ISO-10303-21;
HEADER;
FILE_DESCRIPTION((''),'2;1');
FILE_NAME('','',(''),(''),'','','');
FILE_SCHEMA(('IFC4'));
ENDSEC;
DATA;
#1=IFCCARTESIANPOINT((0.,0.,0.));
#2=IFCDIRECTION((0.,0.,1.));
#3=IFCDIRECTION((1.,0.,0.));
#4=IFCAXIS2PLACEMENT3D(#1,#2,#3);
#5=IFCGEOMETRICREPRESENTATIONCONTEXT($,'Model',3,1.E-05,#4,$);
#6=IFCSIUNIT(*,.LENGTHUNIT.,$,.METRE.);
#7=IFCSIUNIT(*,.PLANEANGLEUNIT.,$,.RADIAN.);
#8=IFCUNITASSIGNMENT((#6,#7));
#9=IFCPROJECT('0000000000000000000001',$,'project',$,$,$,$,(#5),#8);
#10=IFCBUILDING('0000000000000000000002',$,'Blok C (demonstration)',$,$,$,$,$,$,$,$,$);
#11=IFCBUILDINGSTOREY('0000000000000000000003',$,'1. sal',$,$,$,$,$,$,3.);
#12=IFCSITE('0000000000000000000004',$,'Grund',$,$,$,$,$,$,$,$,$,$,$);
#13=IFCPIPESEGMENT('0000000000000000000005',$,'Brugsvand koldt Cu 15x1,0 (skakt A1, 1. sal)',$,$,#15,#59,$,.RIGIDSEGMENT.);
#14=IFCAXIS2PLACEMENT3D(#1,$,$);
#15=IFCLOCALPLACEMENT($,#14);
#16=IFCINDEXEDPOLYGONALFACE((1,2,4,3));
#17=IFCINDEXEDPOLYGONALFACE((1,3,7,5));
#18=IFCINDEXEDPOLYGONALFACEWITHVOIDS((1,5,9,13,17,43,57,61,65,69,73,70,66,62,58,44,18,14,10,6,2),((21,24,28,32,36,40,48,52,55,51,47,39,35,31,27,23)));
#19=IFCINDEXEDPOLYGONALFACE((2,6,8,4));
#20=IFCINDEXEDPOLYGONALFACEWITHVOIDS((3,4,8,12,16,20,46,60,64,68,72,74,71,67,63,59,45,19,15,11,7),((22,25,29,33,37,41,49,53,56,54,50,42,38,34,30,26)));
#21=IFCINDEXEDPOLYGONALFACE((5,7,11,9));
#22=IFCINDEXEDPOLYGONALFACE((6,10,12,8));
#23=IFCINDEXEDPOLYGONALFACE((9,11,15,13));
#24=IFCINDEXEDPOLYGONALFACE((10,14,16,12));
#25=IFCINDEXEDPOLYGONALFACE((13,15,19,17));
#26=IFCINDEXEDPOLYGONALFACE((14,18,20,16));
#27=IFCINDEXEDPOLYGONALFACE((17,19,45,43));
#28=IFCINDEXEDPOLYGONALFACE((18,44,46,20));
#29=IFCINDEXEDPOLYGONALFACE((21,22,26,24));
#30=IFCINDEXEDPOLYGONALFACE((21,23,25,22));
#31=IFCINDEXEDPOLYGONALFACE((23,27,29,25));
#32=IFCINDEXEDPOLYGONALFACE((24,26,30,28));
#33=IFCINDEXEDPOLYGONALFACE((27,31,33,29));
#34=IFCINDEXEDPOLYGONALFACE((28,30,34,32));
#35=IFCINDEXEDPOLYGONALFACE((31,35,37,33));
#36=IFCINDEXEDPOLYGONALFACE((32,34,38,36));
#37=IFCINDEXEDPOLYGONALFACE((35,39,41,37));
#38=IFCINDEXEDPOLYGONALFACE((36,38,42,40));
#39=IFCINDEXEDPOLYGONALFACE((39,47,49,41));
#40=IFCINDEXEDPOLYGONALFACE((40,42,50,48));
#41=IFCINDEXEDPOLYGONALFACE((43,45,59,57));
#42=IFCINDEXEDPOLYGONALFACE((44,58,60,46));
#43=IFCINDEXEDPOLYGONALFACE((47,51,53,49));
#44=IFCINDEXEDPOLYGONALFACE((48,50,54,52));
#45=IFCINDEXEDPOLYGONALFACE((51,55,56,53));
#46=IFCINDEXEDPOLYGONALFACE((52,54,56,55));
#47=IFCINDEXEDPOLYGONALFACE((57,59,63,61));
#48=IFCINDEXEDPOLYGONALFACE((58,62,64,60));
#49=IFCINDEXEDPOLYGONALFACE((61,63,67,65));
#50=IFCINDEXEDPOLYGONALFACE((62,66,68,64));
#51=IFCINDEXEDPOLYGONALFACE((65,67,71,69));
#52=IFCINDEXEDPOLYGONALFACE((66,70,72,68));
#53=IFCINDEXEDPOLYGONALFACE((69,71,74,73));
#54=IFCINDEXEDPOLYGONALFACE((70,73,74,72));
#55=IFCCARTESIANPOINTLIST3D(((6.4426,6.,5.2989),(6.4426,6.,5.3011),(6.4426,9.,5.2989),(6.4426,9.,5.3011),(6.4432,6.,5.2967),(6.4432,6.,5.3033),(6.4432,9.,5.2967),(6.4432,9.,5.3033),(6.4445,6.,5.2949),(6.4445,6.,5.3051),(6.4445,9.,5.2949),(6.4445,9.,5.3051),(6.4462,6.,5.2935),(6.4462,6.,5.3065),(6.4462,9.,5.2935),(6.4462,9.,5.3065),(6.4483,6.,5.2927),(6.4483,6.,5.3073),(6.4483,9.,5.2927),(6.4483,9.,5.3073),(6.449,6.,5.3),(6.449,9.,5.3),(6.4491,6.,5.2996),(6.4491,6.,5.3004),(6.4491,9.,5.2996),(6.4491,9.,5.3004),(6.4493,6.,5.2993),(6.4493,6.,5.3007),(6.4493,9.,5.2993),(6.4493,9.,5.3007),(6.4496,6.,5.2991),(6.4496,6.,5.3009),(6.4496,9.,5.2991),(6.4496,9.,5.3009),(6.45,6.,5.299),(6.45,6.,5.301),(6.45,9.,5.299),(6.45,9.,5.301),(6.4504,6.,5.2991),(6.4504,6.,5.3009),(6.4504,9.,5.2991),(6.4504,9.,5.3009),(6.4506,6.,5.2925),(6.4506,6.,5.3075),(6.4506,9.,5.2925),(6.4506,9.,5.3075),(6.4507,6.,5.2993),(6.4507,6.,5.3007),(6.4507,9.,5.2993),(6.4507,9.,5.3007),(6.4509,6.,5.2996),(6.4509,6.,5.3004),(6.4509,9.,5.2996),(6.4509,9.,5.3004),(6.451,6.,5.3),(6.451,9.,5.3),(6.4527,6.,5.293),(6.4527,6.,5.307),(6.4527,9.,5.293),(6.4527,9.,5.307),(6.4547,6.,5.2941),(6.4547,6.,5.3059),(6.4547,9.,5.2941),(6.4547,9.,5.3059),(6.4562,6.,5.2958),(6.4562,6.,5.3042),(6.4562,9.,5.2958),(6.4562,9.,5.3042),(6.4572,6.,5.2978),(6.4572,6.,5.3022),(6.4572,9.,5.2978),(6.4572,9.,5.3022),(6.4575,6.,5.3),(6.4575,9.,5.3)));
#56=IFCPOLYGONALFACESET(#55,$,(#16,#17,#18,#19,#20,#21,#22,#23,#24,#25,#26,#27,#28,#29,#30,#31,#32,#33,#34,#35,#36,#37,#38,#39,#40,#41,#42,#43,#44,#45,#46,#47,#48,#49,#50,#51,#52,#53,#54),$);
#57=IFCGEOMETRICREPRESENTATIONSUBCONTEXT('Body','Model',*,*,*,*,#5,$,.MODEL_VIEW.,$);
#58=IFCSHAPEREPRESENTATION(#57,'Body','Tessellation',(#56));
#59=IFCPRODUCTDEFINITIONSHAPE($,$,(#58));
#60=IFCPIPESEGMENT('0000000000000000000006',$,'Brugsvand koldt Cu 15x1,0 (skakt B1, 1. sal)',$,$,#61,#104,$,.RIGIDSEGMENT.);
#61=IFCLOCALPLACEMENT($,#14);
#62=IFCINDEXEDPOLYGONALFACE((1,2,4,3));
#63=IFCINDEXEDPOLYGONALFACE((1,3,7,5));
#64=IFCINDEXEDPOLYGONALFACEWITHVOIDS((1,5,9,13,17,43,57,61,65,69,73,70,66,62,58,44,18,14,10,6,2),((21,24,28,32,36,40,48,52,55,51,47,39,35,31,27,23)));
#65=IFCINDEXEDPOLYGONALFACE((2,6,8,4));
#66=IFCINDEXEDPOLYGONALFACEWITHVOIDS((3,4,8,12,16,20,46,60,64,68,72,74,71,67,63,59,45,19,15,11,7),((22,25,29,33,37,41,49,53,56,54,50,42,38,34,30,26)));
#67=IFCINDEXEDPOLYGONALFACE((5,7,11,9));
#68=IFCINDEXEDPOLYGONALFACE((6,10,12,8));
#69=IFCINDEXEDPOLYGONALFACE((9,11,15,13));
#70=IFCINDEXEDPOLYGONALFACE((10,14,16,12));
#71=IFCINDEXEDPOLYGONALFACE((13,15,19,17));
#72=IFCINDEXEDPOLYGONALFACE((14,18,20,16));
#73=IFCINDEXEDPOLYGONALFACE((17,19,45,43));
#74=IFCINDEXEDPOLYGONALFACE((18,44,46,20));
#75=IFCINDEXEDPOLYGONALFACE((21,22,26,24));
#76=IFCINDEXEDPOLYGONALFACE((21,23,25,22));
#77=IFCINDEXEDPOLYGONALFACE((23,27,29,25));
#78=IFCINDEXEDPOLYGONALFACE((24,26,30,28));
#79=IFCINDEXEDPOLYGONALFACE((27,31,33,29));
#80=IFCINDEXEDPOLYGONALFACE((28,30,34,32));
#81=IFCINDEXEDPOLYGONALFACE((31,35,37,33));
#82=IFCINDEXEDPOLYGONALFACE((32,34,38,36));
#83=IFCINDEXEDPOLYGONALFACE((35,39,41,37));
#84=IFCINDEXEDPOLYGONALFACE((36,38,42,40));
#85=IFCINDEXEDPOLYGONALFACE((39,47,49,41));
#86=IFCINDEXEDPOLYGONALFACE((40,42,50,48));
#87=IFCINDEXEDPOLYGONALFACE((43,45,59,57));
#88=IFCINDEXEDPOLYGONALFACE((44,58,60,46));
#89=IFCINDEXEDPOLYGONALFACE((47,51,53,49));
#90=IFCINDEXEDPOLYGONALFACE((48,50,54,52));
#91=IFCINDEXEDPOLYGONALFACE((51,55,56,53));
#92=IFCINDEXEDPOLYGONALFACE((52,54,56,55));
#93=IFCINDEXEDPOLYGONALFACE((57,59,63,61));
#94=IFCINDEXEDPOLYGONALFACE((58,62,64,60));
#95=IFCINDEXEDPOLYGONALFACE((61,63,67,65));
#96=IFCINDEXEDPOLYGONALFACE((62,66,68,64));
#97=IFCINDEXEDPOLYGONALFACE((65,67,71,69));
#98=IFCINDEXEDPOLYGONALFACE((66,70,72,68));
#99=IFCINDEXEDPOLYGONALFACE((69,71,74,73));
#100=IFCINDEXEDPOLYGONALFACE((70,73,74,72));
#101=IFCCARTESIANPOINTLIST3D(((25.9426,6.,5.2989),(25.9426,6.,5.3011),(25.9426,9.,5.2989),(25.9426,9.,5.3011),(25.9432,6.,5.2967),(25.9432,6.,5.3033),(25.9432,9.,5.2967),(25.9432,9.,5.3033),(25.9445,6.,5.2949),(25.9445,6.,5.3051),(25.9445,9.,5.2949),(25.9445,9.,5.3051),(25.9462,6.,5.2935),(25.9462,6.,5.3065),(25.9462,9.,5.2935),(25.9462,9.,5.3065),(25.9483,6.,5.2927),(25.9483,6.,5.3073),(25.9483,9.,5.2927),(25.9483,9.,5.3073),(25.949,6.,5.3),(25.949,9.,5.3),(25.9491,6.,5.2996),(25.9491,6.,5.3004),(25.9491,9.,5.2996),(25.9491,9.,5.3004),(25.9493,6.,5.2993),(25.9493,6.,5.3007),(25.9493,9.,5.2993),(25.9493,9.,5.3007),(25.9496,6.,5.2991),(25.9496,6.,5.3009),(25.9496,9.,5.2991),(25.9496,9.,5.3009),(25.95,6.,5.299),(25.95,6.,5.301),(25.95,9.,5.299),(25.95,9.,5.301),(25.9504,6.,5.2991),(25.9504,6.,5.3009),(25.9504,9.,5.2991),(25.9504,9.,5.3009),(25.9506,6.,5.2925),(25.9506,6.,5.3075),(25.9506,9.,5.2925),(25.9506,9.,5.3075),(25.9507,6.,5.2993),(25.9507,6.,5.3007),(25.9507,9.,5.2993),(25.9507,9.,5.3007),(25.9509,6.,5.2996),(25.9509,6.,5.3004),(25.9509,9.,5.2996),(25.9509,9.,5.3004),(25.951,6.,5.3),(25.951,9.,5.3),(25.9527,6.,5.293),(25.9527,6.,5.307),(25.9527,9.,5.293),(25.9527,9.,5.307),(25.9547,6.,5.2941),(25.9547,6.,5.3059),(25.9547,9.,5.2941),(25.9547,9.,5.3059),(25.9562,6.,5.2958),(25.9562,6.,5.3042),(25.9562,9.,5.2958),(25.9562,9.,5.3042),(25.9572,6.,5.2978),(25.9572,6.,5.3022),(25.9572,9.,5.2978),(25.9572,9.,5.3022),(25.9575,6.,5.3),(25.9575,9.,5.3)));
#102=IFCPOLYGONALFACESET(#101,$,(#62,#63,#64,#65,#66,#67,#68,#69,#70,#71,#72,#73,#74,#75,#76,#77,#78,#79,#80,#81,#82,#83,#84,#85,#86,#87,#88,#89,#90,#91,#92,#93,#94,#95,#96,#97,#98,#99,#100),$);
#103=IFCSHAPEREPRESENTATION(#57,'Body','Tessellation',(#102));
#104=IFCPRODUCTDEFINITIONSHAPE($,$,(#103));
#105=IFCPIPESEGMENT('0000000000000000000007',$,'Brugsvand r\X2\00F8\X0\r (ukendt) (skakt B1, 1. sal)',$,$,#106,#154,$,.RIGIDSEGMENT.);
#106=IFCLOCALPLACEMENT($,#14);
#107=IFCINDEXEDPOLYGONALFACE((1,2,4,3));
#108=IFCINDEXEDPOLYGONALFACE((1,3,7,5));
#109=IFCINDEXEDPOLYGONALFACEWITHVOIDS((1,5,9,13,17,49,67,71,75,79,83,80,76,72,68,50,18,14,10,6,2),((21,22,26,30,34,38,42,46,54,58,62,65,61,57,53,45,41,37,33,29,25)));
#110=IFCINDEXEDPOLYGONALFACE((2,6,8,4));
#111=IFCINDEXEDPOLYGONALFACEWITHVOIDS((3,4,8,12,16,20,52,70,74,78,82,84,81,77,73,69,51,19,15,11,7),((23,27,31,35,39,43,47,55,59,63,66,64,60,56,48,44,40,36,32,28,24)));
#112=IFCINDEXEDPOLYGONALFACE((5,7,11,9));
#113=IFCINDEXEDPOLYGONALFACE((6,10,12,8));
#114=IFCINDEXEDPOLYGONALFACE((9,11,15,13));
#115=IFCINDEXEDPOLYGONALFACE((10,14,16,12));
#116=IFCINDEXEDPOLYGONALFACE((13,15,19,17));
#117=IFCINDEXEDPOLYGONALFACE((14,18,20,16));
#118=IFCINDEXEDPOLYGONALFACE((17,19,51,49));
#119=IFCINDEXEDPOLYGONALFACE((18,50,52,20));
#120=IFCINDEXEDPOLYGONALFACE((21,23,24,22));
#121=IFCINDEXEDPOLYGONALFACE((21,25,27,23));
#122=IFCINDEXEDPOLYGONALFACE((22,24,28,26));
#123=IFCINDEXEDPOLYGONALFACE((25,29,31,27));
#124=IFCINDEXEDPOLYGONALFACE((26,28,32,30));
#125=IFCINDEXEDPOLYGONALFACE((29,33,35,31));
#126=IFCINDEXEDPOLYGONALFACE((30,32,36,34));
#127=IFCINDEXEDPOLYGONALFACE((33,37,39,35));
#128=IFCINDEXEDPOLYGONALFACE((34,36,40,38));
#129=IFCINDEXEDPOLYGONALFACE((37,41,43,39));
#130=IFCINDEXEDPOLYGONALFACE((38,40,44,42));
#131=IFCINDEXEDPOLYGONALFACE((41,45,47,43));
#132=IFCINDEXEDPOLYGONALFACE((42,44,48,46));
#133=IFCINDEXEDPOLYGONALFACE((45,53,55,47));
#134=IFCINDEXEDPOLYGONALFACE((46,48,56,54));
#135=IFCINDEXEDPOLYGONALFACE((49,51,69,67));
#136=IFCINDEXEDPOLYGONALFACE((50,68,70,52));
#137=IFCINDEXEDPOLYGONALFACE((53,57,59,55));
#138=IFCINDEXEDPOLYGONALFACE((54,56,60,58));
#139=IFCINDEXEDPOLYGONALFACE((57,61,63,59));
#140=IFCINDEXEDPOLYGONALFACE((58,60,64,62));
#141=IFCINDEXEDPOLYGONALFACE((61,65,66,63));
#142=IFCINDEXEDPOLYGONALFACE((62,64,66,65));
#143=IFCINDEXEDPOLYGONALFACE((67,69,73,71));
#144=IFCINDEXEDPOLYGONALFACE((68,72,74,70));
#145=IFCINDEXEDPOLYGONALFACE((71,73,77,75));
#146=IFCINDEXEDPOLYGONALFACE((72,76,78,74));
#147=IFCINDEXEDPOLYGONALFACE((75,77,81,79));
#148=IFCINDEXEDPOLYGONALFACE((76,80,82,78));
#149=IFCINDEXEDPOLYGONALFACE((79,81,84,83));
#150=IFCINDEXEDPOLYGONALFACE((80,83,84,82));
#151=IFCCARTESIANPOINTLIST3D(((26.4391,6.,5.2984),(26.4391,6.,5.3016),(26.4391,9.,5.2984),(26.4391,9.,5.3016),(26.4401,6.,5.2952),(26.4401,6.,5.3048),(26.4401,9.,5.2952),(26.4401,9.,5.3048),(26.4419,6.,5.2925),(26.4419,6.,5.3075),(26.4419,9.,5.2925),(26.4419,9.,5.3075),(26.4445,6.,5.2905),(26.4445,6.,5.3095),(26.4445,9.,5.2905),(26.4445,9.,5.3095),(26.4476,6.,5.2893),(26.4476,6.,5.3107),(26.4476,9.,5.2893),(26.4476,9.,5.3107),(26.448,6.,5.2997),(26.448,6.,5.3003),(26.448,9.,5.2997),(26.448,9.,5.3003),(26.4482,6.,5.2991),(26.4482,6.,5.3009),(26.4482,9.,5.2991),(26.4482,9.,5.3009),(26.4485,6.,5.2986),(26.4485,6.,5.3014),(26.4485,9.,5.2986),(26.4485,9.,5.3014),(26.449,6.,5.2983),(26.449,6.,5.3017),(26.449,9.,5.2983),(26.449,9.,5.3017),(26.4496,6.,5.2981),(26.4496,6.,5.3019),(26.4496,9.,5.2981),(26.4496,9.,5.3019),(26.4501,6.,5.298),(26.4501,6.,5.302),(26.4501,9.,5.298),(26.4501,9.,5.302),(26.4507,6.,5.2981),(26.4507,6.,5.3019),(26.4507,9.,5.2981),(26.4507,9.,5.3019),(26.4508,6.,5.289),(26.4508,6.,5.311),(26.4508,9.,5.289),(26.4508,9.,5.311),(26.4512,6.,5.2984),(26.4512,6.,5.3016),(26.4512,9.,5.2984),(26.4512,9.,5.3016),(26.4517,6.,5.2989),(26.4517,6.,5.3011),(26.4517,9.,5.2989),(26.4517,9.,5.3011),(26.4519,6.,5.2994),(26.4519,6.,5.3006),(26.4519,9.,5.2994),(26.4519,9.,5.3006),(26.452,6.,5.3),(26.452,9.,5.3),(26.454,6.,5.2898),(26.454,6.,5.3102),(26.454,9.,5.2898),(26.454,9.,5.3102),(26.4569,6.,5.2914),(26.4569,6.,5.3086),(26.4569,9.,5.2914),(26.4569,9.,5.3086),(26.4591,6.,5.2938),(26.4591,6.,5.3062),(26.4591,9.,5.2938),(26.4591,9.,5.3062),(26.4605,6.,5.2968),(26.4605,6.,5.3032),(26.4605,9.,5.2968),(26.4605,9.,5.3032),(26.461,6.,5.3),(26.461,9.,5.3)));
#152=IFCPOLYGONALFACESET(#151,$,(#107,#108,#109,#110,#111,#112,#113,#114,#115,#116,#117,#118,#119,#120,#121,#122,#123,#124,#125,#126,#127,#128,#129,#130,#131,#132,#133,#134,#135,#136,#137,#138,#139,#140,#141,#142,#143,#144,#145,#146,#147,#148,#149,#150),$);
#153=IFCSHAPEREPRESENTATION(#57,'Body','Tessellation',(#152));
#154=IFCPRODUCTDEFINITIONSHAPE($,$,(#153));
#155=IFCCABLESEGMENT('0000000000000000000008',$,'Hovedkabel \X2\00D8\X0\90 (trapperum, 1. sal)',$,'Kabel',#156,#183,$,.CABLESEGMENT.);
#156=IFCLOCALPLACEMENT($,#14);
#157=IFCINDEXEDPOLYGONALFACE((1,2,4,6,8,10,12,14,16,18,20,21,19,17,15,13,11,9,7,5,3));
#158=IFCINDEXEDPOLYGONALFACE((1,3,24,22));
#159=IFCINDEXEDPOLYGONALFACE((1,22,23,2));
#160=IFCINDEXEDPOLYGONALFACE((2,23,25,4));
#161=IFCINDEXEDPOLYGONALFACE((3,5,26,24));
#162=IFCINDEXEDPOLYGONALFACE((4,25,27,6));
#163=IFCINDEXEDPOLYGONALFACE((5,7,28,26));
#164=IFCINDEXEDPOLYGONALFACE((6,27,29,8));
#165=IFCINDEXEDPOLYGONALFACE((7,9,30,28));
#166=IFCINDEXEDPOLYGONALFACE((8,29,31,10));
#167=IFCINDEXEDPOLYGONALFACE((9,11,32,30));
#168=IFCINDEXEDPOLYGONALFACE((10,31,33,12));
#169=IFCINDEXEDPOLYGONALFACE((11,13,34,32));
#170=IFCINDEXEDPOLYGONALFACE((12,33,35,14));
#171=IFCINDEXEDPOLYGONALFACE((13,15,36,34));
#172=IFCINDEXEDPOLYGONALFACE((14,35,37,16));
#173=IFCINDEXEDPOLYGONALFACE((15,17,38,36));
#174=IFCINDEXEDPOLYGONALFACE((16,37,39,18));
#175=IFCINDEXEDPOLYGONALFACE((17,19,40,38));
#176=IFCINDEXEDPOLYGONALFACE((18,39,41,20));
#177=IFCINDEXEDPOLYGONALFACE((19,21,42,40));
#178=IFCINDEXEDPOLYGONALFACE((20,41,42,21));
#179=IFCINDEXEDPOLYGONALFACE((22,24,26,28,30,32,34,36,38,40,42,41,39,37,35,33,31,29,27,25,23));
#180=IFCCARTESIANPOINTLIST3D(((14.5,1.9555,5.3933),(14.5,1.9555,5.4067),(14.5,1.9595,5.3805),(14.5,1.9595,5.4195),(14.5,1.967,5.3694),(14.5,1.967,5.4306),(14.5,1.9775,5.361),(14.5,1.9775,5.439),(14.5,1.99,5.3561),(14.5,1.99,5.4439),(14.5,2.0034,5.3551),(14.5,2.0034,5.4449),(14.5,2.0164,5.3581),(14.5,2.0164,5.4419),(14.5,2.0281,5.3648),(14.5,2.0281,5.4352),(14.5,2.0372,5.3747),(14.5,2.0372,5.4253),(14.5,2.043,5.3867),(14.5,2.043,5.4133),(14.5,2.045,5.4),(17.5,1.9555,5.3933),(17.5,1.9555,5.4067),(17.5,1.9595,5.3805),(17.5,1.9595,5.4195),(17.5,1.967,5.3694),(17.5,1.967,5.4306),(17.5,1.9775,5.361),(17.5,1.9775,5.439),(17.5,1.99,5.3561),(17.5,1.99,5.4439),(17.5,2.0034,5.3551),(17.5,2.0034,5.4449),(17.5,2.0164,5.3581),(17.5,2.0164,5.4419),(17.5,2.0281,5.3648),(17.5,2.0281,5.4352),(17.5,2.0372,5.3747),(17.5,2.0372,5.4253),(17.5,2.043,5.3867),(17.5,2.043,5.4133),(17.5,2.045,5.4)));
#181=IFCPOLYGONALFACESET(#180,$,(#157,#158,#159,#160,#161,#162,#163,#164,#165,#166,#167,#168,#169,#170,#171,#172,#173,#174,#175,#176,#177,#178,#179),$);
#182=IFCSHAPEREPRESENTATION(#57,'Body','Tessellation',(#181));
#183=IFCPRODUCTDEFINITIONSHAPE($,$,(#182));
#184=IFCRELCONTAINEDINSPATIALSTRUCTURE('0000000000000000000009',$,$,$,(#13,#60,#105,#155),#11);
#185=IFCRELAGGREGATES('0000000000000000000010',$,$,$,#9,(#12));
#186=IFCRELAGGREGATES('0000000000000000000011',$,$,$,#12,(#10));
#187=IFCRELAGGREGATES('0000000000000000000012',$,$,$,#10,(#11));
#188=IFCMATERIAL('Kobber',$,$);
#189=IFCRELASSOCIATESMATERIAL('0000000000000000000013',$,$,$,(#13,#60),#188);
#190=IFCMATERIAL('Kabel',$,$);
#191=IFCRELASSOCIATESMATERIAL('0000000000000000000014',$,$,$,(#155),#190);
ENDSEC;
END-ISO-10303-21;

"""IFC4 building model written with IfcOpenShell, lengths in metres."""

from ifc_helpers import new_model, si_unit, frame, origin_with_axes, place, context, subcontext, project, spatial, circle, hollow_circle, extrude, material, element, save


model = new_model("IFC4")

# Units and contexts
model_context = context("Model", 3, precision=1e-05, world=origin_with_axes())
body_context = subcontext(model_context, "Body", "Model", "MODEL_VIEW")
ifc_project = project(units=[si_unit("LENGTHUNIT", "METRE"), si_unit("PLANEANGLEUNIT", "RADIAN")], contexts=[model_context])

# Site, building, storey
site = spatial("IfcSite", under=ifc_project, Name="Grund")
building = spatial("IfcBuilding", under=site, Name="Blok C (demonstration)")
storey = spatial("IfcBuildingStorey", under=building, Name="1. sal", Elevation=3.0)

# Pipe segments
ifc_material_1 = material(Name="Kobber")
pipe_segment_1_placement = place(None, origin_with_axes())
element("IfcPipeSegment", 1, at=pipe_segment_1_placement, inside=storey, material=ifc_material_1, Name="Brugsvand koldt Cu 15x1,0 (skakt A1, 1. sal)", PredefinedType="RIGIDSEGMENT", context=body_context, shape_type="SweptSolid", body=[
    extrude(hollow_circle(Radius=0.0075, WallThickness=0.0065), frame((6.45, 6.0, 5.3), z_axis=(0.0, 1.0, 0.0), x_axis=(1.0, 0.0, 0.0)), (0.0, 0.0, 1.0), 3.0),
])
pipe_segment_2_placement = place(None, origin_with_axes())
element("IfcPipeSegment", 2, at=pipe_segment_2_placement, inside=storey, material=ifc_material_1, Name="Brugsvand koldt Cu 15x1,0 (skakt B1, 1. sal)", PredefinedType="RIGIDSEGMENT", context=body_context, shape_type="SweptSolid", body=[
    extrude(hollow_circle(Radius=0.0075, WallThickness=0.0065), frame((25.95, 6.0, 5.3), z_axis=(0.0, 1.0, 0.0), x_axis=(1.0, 0.0, 0.0)), (0.0, 0.0, 1.0), 3.0),
])
pipe_segment_3_placement = place(None, origin_with_axes())
element("IfcPipeSegment", 3, at=pipe_segment_3_placement, inside=storey, Name="Brugsvand rør (ukendt) (skakt B1, 1. sal)", PredefinedType="RIGIDSEGMENT", context=body_context, shape_type="SweptSolid", body=[
    extrude(hollow_circle(Radius=0.011, WallThickness=0.009), frame((26.45, 6.0, 5.3), z_axis=(0.0, 1.0, 0.0), x_axis=(1.0, 0.0, 0.0)), (0.0, 0.0, 1.0), 3.0),
])

# Cable segment
ifc_material_2 = material(Name="Kabel")
cable_segment_placement = place(None, origin_with_axes())
element("IfcCableSegment", 4, at=cable_segment_placement, inside=storey, material=ifc_material_2, Name="Hovedkabel Ø90 (trapperum, 1. sal)", ObjectType="Kabel", PredefinedType="CABLESEGMENT", context=body_context, shape_type="SweptSolid", body=[
    extrude(circle(Radius=0.045), frame((14.5, 2.0, 5.4), z_axis=(1.0, 0.0, 0.0), x_axis=(0.0, 1.0, 0.0)), (0.0, 0.0, 1.0), 3.0),
])

save(model, "model.ifc")
